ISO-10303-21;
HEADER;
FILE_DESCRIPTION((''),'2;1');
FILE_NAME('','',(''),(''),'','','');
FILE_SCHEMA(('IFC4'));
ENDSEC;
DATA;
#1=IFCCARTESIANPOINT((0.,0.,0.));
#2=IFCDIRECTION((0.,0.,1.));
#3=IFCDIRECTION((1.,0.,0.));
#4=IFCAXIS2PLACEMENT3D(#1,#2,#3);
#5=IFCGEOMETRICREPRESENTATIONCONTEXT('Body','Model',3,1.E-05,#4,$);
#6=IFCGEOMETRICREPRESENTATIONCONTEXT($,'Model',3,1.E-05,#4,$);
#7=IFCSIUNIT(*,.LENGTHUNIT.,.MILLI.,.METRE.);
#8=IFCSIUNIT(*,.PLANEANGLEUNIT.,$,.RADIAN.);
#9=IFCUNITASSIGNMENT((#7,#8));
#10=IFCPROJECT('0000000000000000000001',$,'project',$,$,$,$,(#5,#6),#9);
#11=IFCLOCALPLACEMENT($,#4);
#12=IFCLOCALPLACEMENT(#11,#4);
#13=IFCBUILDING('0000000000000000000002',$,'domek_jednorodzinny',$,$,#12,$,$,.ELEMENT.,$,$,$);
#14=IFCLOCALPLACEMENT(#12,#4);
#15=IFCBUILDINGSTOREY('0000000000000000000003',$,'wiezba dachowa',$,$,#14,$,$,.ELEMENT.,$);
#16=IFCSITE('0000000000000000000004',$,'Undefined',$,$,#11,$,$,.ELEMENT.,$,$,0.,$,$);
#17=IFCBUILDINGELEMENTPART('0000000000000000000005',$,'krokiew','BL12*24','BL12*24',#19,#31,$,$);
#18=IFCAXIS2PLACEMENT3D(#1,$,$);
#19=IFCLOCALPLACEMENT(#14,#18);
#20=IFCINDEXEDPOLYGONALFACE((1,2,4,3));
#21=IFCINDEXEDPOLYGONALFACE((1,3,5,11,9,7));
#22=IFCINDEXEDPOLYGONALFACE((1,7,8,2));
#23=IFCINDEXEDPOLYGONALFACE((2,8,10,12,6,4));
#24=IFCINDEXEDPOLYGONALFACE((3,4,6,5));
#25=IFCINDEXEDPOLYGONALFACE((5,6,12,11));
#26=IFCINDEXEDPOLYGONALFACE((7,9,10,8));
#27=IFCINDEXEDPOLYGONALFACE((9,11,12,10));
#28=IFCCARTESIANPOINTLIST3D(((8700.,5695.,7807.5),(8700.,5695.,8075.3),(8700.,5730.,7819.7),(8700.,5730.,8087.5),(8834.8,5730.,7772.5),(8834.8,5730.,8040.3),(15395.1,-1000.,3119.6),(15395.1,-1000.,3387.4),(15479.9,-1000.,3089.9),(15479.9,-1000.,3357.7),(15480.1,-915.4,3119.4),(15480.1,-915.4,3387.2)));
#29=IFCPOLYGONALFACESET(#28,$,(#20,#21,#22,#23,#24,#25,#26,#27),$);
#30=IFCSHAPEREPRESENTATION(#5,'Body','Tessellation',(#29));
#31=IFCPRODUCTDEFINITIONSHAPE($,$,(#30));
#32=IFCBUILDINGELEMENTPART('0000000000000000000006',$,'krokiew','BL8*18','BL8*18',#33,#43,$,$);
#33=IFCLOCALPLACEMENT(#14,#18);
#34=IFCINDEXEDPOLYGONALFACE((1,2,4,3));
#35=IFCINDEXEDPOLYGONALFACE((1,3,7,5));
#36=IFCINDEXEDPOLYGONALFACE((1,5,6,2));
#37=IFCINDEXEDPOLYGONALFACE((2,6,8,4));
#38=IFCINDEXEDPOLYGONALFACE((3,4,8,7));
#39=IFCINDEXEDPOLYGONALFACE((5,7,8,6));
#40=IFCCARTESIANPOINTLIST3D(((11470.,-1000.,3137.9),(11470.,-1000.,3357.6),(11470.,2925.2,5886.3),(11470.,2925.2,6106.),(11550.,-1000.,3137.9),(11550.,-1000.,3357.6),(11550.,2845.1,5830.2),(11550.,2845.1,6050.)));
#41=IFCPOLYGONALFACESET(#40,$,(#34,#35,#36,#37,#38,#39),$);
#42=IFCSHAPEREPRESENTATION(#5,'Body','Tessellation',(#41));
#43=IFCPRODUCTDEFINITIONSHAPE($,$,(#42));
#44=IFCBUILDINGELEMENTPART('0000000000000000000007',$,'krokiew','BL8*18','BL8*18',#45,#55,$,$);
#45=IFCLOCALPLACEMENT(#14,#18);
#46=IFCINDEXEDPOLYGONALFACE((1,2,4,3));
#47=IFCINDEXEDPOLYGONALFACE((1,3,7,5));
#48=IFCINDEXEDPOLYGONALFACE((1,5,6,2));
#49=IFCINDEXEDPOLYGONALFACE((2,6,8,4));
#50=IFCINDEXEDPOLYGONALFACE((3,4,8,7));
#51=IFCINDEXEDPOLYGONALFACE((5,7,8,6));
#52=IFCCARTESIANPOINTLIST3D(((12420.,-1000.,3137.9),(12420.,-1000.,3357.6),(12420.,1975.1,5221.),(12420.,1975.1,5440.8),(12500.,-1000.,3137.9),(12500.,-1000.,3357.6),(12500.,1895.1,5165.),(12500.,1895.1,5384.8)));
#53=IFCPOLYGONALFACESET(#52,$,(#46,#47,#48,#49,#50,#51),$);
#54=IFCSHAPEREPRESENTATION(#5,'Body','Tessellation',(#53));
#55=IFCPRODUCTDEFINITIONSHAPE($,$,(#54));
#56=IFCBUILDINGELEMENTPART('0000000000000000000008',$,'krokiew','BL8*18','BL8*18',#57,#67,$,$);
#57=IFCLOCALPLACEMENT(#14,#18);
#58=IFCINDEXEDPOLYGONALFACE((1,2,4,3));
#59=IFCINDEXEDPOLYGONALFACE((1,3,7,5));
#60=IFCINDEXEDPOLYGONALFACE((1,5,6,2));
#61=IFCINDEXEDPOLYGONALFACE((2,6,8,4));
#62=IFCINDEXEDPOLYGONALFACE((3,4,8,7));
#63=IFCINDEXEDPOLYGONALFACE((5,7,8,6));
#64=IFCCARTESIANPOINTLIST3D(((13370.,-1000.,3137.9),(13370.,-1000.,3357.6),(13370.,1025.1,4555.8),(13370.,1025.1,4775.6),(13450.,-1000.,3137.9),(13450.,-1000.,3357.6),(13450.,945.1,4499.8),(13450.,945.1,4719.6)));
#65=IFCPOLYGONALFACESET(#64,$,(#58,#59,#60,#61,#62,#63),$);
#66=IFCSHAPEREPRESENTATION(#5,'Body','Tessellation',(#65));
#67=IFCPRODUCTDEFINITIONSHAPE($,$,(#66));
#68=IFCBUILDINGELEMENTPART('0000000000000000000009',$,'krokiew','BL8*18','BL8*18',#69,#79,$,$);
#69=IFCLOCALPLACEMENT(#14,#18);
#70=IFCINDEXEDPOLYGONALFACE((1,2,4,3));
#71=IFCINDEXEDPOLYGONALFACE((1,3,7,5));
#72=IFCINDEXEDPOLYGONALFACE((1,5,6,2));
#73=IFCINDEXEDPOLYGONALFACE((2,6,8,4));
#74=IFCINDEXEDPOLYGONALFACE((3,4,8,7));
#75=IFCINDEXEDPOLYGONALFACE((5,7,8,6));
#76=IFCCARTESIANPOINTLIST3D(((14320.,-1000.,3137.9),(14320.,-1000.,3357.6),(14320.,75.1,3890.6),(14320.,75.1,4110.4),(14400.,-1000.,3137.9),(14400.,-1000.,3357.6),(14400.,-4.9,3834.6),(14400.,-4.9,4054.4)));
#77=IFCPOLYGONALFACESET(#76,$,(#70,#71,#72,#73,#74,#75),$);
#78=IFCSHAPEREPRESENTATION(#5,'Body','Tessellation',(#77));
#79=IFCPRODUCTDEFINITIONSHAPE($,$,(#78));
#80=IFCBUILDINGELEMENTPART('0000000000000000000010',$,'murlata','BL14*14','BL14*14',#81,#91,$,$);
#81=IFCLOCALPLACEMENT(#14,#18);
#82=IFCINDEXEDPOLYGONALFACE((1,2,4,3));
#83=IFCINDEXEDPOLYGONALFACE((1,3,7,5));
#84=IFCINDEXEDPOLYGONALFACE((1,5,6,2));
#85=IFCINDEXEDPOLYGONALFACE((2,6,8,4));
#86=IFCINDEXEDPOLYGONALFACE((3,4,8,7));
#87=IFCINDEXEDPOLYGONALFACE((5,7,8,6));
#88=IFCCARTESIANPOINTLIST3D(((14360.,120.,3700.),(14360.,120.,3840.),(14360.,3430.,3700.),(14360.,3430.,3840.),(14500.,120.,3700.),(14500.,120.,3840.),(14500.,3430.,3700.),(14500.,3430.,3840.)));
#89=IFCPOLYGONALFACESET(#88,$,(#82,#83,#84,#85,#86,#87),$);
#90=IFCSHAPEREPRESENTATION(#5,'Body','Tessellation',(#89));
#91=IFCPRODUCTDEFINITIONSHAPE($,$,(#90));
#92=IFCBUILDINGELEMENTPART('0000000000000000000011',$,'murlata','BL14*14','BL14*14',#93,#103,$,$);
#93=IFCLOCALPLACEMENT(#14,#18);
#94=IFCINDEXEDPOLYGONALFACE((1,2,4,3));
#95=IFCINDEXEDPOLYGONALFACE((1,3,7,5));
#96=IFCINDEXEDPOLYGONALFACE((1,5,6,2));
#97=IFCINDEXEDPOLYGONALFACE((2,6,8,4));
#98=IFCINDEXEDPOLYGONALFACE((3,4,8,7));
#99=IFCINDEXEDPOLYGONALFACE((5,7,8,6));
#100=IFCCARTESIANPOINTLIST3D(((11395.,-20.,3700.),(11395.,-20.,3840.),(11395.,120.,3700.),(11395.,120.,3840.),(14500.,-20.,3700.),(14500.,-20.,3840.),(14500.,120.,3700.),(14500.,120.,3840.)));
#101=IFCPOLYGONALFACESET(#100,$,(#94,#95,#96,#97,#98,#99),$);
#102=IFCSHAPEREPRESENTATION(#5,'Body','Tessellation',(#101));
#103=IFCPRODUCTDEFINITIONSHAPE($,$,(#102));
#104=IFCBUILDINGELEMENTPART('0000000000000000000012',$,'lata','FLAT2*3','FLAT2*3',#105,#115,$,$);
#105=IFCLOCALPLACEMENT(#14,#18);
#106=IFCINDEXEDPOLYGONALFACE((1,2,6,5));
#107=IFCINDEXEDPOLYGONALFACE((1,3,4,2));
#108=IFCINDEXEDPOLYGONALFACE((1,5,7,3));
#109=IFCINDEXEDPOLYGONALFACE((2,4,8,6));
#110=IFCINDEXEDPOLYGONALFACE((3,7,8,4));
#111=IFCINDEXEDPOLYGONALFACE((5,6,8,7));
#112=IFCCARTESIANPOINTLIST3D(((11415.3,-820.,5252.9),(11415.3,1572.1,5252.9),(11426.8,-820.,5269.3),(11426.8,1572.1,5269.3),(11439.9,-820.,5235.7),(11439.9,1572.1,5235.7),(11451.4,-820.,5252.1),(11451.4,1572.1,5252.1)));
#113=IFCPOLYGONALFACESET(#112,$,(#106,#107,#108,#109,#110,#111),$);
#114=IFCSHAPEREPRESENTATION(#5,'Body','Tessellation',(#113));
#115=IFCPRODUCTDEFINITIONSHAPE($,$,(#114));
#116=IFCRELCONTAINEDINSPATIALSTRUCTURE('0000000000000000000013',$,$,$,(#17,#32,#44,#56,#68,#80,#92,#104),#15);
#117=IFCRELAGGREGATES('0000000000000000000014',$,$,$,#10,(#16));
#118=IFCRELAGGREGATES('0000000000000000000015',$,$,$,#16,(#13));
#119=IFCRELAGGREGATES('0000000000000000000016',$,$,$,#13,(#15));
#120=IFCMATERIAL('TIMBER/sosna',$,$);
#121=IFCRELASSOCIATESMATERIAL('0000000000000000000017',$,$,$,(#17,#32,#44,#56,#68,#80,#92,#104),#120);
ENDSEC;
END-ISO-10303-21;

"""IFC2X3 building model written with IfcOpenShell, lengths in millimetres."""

from ifc_helpers import new_model, si_unit, frame, origin_with_axes, origin_2d_with_axis, place, context, project, spatial, rectangle, extrude, clip, halfspace, material, element, save


model = new_model("IFC2X3")

# Units and contexts
model_context_1 = context("Model", 3, precision=1e-05, world=origin_with_axes(), identifier="Body")
model_context_2 = context("Model", 3, precision=1e-05, world=origin_with_axes())
ifc_project = project(units=[si_unit("LENGTHUNIT", "METRE", prefix="MILLI"), si_unit("PLANEANGLEUNIT", "RADIAN")], contexts=[model_context_1, model_context_2])

# Site, building, storey
site_placement = place(None, origin_with_axes())
site = spatial("IfcSite", under=ifc_project, at=site_placement, Name="Undefined", CompositionType="ELEMENT", RefElevation=0.0)
building_placement = place(site_placement, origin_with_axes())
building = spatial("IfcBuilding", under=site, at=building_placement, Name="domek_jednorodzinny", CompositionType="ELEMENT")
storey_placement = place(building_placement, origin_with_axes())
storey = spatial("IfcBuildingStorey", under=building, at=storey_placement, Name="wiezba dachowa", CompositionType="ELEMENT")

# Building element parts
ifc_material = material(Name="TIMBER/sosna")
building_element_part_1_placement = place(storey_placement, frame((15537.3, -1057.3, 3183.6), z_axis=(0.313751, -0.313751, 0.89617), x_axis=(-0.633688, 0.633688, 0.443711)))
element("IfcBuildingElementPart", 1, at=building_element_part_1_placement, inside=storey, material=ifc_material, Name="krokiew", Description="BL12*24", ObjectType="BL12*24", context=model_context_1, shape_type="Clipping", body=[
    clip(clip(clip(clip(extrude(rectangle(XDim=120.0, YDim=240.0, at=origin_2d_with_axis()), frame((10870.2, 0.0, 0.0), z_axis=(-1.0, 0.0, 0.0), x_axis=(0.0, -1.0, 0.0)), (0.0, 0.0, 1.0), 10870.2), halfspace(frame((10584.5, -60.0, -120.0), z_axis=(0.633693, -0.707101, -0.313753), x_axis=(0.443711, 0.0, 0.89617)), False)), halfspace(frame((10797.4, -60.0, -120.0), z_axis=(0.633074, 0.707791, -0.313447), x_axis=(0.443711, 0.0, 0.89617)), False)), halfspace(frame((-35.3, 60.0, -120.0), z_axis=(-0.635836, -0.704701, 0.314814), x_axis=(0.443711, 0.0, 0.89617)), False)), halfspace(frame((98.0, 60.0, -120.0), z_axis=(-0.633686, 0.707109, 0.31375), x_axis=(0.443711, 0.0, 0.89617)), False)),
])
building_element_part_2_placement = place(storey_placement, frame((11510.0, -1051.6, 3211.6), z_axis=(0.0, -0.573576, 0.819152), x_axis=(0.0, 0.819154, 0.573574)))
element("IfcBuildingElementPart", 2, at=building_element_part_2_placement, inside=storey, material=ifc_material, Name="krokiew", Description="BL8*18", ObjectType="BL8*18", context=model_context_1, shape_type="Clipping", body=[
    clip(clip(clip(extrude(rectangle(XDim=80.0, YDim=180.0, at=origin_2d_with_axis()), frame((8341.8, 0.0, 0.0), z_axis=(-1.0, 0.0, 0.0), x_axis=(0.0, -1.0, 0.0)), (0.0, 0.0, 1.0), 8341.8), halfspace(frame((0.0, 40.0, -90.0), z_axis=(-0.819152, 0.0, 0.573576), x_axis=(0.573578, 0.0, 0.819151)), False)), halfspace(frame((8215.8, -40.0, -90.0), z_axis=(0.819151, 0.0, -0.573578), x_axis=(0.573578, 0.0, 0.819151)), False)), halfspace(frame((4694.0, -40.0, -90.0), z_axis=(0.578968, -0.707424, -0.405398), x_axis=(0.573578, 0.0, 0.819151)), False)),
])
building_element_part_3_placement = place(storey_placement, frame((12460.0, -1051.6, 3211.6), z_axis=(0.0, -0.573576, 0.819152), x_axis=(0.0, 0.819154, 0.573574)))
element("IfcBuildingElementPart", 3, at=building_element_part_3_placement, inside=storey, material=ifc_material, Name="krokiew", Description="BL8*18", ObjectType="BL8*18", context=model_context_1, shape_type="Clipping", body=[
    clip(clip(clip(extrude(rectangle(XDim=80.0, YDim=180.0, at=origin_2d_with_axis()), frame((8341.8, 0.0, 0.0), z_axis=(-1.0, 0.0, 0.0), x_axis=(0.0, -1.0, 0.0)), (0.0, 0.0, 1.0), 8341.8), halfspace(frame((0.0, 40.0, -90.0), z_axis=(-0.819152, 0.0, 0.573576), x_axis=(0.573578, 0.0, 0.819151)), False)), halfspace(frame((8215.8, -40.0, -90.0), z_axis=(0.819151, 0.0, -0.573578), x_axis=(0.573578, 0.0, 0.819151)), False)), halfspace(frame((3534.2, -40.0, -90.0), z_axis=(0.579228, -0.707106, -0.40558), x_axis=(0.573578, 0.0, 0.819151)), False)),
])
building_element_part_4_placement = place(storey_placement, frame((13410.0, -1051.6, 3211.6), z_axis=(0.0, -0.573576, 0.819152), x_axis=(0.0, 0.819154, 0.573574)))
element("IfcBuildingElementPart", 4, at=building_element_part_4_placement, inside=storey, material=ifc_material, Name="krokiew", Description="BL8*18", ObjectType="BL8*18", context=model_context_1, shape_type="Clipping", body=[
    clip(clip(clip(extrude(rectangle(XDim=80.0, YDim=180.0, at=origin_2d_with_axis()), frame((8341.8, 0.0, 0.0), z_axis=(-1.0, 0.0, 0.0), x_axis=(0.0, -1.0, 0.0)), (0.0, 0.0, 1.0), 8341.8), halfspace(frame((0.0, 40.0, -90.0), z_axis=(-0.819152, 0.0, 0.573576), x_axis=(0.573578, 0.0, 0.819151)), False)), halfspace(frame((8215.8, -40.0, -90.0), z_axis=(0.819151, 0.0, -0.573578), x_axis=(0.573578, 0.0, 0.819151)), False)), halfspace(frame((2374.5, -40.0, -90.0), z_axis=(0.579228, -0.707106, -0.40558), x_axis=(0.573578, 0.0, 0.819151)), False)),
])
building_element_part_5_placement = place(storey_placement, frame((14360.0, -1051.6, 3211.6), z_axis=(0.0, -0.573576, 0.819152), x_axis=(0.0, 0.819154, 0.573574)))
element("IfcBuildingElementPart", 5, at=building_element_part_5_placement, inside=storey, material=ifc_material, Name="krokiew", Description="BL8*18", ObjectType="BL8*18", context=model_context_1, shape_type="Clipping", body=[
    clip(clip(clip(extrude(rectangle(XDim=80.0, YDim=180.0, at=origin_2d_with_axis()), frame((8341.8, 0.0, 0.0), z_axis=(-1.0, 0.0, 0.0), x_axis=(0.0, -1.0, 0.0)), (0.0, 0.0, 1.0), 8341.8), halfspace(frame((0.0, 40.0, -90.0), z_axis=(-0.819152, 0.0, 0.573576), x_axis=(0.573578, 0.0, 0.819151)), False)), halfspace(frame((8215.8, -40.0, -90.0), z_axis=(0.819151, 0.0, -0.573578), x_axis=(0.573578, 0.0, 0.819151)), False)), halfspace(frame((1214.8, -40.0, -90.0), z_axis=(0.579228, -0.707106, -0.40558), x_axis=(0.573578, 0.0, 0.819151)), False)),
])
building_element_part_6_placement = place(storey_placement, frame((14430.0, 120.0, 3770.0), z_axis=(0.0, 0.0, 1.0), x_axis=(0.0, 1.0, 0.0)))
element("IfcBuildingElementPart", 6, at=building_element_part_6_placement, inside=storey, material=ifc_material, Name="murlata", Description="BL14*14", ObjectType="BL14*14", context=model_context_1, shape_type="SweptSolid", body=[
    extrude(rectangle(XDim=140.0, YDim=140.0, at=origin_2d_with_axis()), frame((3310.0, 0.0, 0.0), z_axis=(-1.0, 0.0, 0.0), x_axis=(0.0, -1.0, 0.0)), (0.0, 0.0, 1.0), 3310.0),
])
building_element_part_7_placement = place(storey_placement, frame((11395.0, 50.0, 3770.0), z_axis=(0.0, 0.0, 1.0), x_axis=(1.0, 0.0, 0.0)))
element("IfcBuildingElementPart", 7, at=building_element_part_7_placement, inside=storey, material=ifc_material, Name="murlata", Description="BL14*14", ObjectType="BL14*14", context=model_context_1, shape_type="SweptSolid", body=[
    extrude(rectangle(XDim=140.0, YDim=140.0, at=origin_2d_with_axis()), frame((3105.0, 0.0, 0.0), z_axis=(-1.0, 0.0, 0.0), x_axis=(0.0, -1.0, 0.0)), (0.0, 0.0, 1.0), 3105.0),
])
building_element_part_8_placement = place(storey_placement, frame((11433.3, 1572.1, 5252.5), z_axis=(-0.819152, 0.0, 0.573576), x_axis=(0.0, -1.0, 0.0)))
element("IfcBuildingElementPart", 8, at=building_element_part_8_placement, inside=storey, material=ifc_material, Name="lata", Description="FLAT2*3", ObjectType="FLAT2*3", context=model_context_1, shape_type="SweptSolid", body=[
    extrude(rectangle(XDim=20.0, YDim=30.0, at=origin_2d_with_axis()), frame((2392.1, 0.0, 0.0), z_axis=(-1.0, 0.0, 0.0), x_axis=(0.0, -1.0, 0.0)), (0.0, 0.0, 1.0), 2392.1),
])

save(model, "model.ifc")
